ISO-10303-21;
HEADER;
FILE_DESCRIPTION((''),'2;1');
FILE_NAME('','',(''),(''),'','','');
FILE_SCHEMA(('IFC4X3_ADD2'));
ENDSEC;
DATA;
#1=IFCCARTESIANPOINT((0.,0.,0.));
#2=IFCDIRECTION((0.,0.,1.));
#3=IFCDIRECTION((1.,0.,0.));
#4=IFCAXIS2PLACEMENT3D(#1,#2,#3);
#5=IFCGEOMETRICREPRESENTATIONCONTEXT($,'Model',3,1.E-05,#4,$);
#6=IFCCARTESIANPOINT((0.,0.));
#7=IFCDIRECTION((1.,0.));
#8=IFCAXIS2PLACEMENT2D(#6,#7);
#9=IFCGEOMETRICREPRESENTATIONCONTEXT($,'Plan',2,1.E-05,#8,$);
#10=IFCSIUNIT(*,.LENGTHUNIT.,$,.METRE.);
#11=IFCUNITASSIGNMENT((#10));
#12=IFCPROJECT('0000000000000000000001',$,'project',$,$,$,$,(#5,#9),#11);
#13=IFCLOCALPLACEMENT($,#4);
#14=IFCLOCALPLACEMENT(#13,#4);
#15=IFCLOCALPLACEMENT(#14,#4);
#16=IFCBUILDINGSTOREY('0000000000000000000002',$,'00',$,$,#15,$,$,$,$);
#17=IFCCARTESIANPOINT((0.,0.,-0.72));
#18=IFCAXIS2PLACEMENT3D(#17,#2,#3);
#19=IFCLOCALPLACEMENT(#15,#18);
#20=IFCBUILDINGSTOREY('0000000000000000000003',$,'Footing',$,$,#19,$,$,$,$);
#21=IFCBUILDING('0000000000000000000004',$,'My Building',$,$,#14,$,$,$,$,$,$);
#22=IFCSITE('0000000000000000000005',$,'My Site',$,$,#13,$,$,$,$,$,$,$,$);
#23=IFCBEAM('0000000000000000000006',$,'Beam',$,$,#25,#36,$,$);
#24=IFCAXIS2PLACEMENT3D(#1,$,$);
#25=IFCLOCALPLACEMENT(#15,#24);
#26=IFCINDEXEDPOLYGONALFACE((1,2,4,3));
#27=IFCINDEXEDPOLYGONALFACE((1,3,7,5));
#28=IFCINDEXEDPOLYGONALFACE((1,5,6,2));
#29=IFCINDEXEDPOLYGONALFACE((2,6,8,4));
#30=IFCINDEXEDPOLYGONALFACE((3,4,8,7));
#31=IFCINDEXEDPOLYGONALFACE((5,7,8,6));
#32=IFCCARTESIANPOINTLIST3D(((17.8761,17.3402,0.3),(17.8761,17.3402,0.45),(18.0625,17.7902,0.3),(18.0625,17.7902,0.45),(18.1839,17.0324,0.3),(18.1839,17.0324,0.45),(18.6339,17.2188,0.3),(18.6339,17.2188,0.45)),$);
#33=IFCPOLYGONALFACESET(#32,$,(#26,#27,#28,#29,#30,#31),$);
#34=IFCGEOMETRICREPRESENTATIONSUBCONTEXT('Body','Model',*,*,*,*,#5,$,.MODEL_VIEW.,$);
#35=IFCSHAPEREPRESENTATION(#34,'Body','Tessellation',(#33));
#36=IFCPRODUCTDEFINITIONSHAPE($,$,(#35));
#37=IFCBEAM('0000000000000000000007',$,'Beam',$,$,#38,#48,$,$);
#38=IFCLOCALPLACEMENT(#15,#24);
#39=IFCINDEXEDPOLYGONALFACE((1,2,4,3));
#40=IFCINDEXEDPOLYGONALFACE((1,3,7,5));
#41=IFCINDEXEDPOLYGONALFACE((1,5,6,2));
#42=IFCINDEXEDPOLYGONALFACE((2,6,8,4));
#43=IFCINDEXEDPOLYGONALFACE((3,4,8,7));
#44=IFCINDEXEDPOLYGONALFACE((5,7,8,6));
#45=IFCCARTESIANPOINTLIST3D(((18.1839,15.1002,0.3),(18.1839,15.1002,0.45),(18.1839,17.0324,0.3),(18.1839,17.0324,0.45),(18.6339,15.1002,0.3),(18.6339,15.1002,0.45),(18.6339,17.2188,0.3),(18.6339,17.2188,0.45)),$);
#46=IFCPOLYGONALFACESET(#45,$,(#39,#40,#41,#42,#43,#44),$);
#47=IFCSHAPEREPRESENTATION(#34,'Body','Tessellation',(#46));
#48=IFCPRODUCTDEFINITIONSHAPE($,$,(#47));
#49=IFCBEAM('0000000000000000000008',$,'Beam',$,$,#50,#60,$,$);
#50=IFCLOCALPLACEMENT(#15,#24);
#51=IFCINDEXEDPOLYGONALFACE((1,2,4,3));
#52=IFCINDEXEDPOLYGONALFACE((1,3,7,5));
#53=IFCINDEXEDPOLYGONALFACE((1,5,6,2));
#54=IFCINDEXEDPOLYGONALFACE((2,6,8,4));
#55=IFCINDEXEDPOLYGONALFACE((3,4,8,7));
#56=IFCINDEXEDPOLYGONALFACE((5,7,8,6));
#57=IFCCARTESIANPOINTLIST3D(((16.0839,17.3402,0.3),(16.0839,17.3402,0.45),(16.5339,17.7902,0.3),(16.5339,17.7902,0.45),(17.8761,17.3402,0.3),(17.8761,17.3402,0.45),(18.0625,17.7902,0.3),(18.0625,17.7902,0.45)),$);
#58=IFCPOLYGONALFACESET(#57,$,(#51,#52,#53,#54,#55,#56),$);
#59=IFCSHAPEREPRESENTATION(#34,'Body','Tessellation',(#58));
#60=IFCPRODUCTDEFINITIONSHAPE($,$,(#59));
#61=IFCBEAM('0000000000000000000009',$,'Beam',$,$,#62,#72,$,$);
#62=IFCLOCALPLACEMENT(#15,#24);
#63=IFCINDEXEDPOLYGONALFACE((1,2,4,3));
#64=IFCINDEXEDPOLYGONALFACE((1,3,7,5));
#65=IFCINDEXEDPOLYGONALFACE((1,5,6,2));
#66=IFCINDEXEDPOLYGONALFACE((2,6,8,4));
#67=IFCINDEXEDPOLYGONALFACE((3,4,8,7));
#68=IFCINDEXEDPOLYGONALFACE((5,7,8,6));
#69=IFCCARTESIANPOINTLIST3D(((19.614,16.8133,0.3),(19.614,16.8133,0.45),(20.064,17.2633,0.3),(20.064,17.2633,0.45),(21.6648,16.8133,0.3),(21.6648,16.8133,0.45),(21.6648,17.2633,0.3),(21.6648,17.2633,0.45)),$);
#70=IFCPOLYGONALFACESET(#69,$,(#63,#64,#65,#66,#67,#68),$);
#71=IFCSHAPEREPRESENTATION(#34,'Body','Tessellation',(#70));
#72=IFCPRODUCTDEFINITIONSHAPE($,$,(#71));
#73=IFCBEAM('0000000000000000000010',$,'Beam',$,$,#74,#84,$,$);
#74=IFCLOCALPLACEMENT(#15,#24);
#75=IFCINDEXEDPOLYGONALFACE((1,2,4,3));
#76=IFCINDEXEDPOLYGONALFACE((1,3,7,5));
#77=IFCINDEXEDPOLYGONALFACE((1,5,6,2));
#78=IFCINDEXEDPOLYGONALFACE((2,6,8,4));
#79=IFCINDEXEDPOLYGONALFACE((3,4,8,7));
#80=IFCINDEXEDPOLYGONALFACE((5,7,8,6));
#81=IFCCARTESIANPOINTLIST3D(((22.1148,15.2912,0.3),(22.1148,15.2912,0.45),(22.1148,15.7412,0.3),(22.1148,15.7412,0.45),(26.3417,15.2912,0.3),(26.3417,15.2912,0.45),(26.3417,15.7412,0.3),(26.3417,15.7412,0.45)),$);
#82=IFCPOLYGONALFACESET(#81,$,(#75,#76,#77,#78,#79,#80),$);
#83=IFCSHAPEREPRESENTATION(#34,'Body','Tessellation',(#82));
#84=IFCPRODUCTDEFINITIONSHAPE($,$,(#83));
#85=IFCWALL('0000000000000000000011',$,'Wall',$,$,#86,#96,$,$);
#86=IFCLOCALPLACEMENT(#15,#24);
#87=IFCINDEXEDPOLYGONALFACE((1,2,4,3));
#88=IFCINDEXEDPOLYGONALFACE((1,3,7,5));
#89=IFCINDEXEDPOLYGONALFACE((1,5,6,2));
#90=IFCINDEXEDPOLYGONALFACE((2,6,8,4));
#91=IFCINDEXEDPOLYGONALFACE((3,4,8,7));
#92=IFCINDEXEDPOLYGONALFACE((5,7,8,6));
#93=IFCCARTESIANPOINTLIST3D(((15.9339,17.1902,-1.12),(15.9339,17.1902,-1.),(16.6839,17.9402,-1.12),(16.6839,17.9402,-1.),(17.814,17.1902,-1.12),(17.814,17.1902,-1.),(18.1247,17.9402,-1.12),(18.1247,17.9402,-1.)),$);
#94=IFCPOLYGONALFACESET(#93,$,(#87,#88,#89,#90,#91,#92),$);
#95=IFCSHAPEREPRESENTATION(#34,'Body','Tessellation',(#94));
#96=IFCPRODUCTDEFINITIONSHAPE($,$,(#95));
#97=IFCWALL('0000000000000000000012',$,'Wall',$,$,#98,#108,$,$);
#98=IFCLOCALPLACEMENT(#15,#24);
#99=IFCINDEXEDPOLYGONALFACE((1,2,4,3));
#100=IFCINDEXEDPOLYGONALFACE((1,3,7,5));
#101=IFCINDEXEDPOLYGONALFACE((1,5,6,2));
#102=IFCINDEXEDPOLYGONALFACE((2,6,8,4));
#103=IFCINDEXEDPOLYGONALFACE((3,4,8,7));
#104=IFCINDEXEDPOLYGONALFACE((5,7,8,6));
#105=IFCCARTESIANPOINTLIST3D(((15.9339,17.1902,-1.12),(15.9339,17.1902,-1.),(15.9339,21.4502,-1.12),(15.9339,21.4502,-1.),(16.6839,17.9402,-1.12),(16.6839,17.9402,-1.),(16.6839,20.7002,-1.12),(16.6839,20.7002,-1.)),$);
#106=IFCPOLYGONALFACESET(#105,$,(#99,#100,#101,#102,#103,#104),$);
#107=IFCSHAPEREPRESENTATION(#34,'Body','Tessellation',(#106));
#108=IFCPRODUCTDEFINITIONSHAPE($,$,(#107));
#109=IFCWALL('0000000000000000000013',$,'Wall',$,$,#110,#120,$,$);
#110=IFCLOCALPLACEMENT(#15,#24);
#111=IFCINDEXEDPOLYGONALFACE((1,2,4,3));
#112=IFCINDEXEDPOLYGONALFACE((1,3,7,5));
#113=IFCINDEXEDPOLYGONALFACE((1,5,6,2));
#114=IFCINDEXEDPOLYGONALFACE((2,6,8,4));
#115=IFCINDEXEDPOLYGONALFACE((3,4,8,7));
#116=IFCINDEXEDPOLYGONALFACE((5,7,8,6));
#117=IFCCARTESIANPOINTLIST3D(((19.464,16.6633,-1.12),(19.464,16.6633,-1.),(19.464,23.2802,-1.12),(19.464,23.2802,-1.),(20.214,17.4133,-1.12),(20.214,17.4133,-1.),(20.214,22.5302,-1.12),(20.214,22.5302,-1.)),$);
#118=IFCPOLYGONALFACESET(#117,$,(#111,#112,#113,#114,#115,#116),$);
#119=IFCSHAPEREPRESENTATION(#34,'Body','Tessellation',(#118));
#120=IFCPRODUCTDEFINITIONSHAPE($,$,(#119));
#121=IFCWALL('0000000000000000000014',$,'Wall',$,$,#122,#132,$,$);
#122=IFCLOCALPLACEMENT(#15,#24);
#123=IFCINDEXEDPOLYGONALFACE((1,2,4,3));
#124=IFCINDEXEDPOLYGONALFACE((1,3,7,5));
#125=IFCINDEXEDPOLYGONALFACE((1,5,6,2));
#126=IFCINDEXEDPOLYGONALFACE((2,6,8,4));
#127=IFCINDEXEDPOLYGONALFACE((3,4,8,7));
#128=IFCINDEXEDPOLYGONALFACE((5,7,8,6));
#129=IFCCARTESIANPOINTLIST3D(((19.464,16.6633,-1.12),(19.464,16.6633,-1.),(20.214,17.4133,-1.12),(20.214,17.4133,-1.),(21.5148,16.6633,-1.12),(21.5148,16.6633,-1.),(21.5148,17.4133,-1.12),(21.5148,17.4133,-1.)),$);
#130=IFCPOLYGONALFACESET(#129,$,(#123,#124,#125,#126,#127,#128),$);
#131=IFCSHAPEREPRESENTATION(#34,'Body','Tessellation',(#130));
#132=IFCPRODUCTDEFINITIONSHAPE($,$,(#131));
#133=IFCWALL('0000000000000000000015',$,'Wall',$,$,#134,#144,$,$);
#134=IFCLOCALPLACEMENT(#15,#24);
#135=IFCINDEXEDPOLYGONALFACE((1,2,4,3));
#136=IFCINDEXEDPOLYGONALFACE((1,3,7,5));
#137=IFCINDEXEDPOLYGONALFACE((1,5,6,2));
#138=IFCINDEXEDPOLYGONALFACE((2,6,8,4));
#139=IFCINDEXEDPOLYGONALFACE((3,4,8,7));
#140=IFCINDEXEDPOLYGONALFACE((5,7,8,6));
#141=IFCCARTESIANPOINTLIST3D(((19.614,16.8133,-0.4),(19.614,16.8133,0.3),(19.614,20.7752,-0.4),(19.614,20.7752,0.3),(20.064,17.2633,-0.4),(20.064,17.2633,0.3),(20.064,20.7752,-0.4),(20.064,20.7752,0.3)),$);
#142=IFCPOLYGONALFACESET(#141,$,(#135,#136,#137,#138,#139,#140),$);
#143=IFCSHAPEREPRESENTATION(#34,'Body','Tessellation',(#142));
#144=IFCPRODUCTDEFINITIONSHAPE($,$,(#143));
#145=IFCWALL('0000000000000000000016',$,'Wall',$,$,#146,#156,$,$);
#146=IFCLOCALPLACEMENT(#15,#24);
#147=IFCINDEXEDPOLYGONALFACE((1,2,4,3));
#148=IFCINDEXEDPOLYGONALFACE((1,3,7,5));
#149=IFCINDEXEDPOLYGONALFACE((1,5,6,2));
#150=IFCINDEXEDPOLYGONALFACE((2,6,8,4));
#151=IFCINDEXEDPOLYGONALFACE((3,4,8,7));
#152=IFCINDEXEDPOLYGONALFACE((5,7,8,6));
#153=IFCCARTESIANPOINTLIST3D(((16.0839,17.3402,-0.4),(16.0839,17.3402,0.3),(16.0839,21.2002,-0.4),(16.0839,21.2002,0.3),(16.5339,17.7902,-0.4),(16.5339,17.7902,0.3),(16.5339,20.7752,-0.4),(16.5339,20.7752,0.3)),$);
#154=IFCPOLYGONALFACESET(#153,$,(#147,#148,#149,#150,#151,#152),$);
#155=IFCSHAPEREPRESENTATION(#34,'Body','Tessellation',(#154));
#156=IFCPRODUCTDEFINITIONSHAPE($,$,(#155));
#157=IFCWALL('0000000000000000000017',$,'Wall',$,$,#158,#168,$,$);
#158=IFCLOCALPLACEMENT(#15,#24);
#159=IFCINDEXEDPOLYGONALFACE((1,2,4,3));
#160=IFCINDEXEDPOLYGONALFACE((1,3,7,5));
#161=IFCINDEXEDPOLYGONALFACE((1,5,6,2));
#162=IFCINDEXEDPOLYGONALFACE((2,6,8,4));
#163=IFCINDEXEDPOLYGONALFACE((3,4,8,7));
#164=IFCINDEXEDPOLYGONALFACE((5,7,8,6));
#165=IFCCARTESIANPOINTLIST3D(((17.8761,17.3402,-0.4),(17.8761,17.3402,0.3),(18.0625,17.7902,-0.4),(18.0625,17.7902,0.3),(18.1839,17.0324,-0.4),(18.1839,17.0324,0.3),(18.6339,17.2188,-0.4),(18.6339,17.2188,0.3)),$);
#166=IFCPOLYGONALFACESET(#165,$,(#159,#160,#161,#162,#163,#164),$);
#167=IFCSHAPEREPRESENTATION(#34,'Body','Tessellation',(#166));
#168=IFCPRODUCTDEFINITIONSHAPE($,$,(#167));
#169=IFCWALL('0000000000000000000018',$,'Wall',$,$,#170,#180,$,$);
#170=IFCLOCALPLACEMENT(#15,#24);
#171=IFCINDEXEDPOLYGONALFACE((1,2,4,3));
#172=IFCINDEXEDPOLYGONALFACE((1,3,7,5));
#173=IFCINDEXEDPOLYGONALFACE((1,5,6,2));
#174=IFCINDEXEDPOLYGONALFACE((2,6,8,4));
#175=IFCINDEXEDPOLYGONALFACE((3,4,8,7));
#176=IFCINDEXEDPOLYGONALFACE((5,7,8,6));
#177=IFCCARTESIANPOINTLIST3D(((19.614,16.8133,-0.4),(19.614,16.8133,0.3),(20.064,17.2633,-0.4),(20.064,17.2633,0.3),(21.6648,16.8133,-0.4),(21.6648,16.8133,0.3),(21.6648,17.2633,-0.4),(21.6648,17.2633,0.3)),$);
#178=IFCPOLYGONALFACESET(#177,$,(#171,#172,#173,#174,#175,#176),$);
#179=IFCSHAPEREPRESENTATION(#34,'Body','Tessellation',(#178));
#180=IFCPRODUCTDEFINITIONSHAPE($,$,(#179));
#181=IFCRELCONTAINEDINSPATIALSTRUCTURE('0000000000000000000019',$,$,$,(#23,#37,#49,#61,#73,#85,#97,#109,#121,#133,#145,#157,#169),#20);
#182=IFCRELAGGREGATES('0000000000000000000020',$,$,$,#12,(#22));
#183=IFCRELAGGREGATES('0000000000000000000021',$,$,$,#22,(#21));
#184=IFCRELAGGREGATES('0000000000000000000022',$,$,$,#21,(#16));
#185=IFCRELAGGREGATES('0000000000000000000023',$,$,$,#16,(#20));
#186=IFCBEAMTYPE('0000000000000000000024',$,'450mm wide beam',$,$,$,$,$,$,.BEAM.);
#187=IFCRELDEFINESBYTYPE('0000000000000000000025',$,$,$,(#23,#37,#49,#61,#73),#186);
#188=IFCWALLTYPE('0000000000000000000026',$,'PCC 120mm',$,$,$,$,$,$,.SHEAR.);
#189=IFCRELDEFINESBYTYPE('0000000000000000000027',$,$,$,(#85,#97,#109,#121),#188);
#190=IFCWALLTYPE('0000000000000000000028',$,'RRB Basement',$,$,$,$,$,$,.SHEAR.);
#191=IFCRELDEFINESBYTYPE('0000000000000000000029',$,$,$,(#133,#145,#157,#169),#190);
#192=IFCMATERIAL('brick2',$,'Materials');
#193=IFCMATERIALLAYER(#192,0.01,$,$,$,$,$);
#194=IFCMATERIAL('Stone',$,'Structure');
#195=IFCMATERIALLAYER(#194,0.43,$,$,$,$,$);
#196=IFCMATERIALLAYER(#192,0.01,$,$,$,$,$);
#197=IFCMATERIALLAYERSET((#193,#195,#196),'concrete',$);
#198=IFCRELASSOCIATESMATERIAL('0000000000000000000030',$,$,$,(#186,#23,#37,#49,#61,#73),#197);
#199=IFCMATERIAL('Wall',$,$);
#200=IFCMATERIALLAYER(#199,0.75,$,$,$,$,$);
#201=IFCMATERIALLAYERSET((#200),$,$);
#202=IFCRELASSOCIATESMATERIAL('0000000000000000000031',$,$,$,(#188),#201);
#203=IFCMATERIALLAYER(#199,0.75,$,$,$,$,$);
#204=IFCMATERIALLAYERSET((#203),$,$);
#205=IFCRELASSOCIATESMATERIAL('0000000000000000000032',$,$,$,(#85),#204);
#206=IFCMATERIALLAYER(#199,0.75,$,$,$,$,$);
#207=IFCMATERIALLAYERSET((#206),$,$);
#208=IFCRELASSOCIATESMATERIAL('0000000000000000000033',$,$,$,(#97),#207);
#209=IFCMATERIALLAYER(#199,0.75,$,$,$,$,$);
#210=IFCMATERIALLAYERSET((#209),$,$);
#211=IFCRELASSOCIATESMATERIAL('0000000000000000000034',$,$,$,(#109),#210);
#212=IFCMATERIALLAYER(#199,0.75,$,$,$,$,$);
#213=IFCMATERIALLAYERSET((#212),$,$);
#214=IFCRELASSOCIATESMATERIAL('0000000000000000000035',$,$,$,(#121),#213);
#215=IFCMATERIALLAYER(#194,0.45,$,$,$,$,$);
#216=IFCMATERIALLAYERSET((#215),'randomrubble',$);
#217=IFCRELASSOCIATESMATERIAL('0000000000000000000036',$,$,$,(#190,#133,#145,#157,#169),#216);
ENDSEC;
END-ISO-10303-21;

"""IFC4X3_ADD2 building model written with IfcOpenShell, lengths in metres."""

from ifc_helpers import new_model, si_unit, frame, origin_with_axes, origin_2d_with_axis, place, context, subcontext, project, spatial, line, indexed_curve, outline, extrude, material, layer, layer_set, layer_usage, type_object, element, save


model = new_model("IFC4X3_ADD2")

# Units and contexts
model_context = context("Model", 3, precision=1e-05, world=origin_with_axes())
plan_context = context("Plan", 2, precision=1e-05, world=origin_2d_with_axis())
body_context = subcontext(model_context, "Body", "Model", "MODEL_VIEW")
ifc_project = project(units=[si_unit("LENGTHUNIT", "METRE")], contexts=[model_context, plan_context])

# Site, building, storeys
site_placement = place(None, origin_with_axes())
site = spatial("IfcSite", under=ifc_project, at=site_placement, Name="My Site")
building_placement = place(site_placement, origin_with_axes())
building = spatial("IfcBuilding", under=site, at=building_placement, Name="My Building")
storey_1_placement = place(building_placement, origin_with_axes())
storey_1 = spatial("IfcBuildingStorey", under=building, at=storey_1_placement, Name="00")
storey_2_placement = place(storey_1_placement, frame((0.0, 0.0, -0.72), z_axis=(0.0, 0.0, 1.0), x_axis=(1.0, 0.0, 0.0)))
storey_2 = spatial("IfcBuildingStorey", under=storey_1, at=storey_2_placement, Name="Footing")

# Beams
ifc_material_1 = material(Name="brick2", Category="Materials")
ifc_layer_1 = layer(ifc_material_1, 0.01)
ifc_material_2 = material(Name="Stone", Category="Structure")
ifc_layer_2 = layer(ifc_material_2, 0.43)
ifc_layer_3 = layer(ifc_material_1, 0.01)
ifc_layer_set_1 = layer_set([ifc_layer_1, ifc_layer_2, ifc_layer_3], Name="concrete")
ifc_layer_usage_1 = layer_usage(ifc_layer_set_1, "AXIS2", "NEGATIVE", 0.0)
beam_type = type_object("IfcBeamType", Name="450mm wide beam", PredefinedType="BEAM", material=ifc_layer_set_1)
beam_1_placement = place(storey_2_placement, frame((18.1839, 17.0324, 1.02), z_axis=(0.0, 0.0, 1.0), x_axis=(-0.707107, 0.707107, 0.0)))
element("IfcBeam", 1, at=beam_1_placement, inside=storey_2, type_object=beam_type, material=ifc_layer_usage_1, Name="Beam", context=body_context, shape_type="SweptSolid", body=[
    extrude(outline(indexed_curve([(-0.1864, -0.45), (0.0, 0.0), (0.4353, 0.0), (0.6217, -0.45)], segments=[line(1, 2, 3, 4, 1)])), origin_with_axes(), (0.0, 0.0, 1.0), 0.15),
])
ifc_layer_usage_2 = layer_usage(ifc_layer_set_1, "AXIS2", "POSITIVE", 0.0)
beam_2_placement = place(storey_2_placement, frame((18.1839, 17.0324, 1.02), z_axis=(0.0, 0.0, 1.0), x_axis=(0.0, -1.0, 0.0)))
element("IfcBeam", 2, at=beam_2_placement, inside=storey_2, type_object=beam_type, material=ifc_layer_usage_2, Name="Beam", context=body_context, shape_type="SweptSolid", body=[
    extrude(outline(indexed_curve([(0.0, 0.0), (-0.1864, 0.45), (1.9322, 0.45), (1.9322, 0.0)], segments=[line(1, 2, 3, 4, 1)])), origin_with_axes(), (0.0, 0.0, 1.0), 0.15),
])
ifc_layer_usage_3 = layer_usage(ifc_layer_set_1, "AXIS2", "POSITIVE", 0.0)
beam_3_placement = place(storey_2_placement, frame((16.0839, 17.3402, 1.02), z_axis=(0.0, 0.0, 1.0), x_axis=(1.0, 0.0, 0.0)))
element("IfcBeam", 3, at=beam_3_placement, inside=storey_2, type_object=beam_type, material=ifc_layer_usage_3, Name="Beam", context=body_context, shape_type="SweptSolid", body=[
    extrude(outline(indexed_curve([(0.0, 0.0), (0.45, 0.45), (1.9786, 0.45), (1.7922, 0.0)], segments=[line(1, 2, 3, 4, 1)])), origin_with_axes(), (0.0, 0.0, 1.0), 0.15),
])
ifc_layer_usage_4 = layer_usage(ifc_layer_set_1, "AXIS2", "NEGATIVE", 0.0)
beam_4_placement = place(storey_2_placement, frame((20.064, 17.2633, 1.02), z_axis=(0.0, 0.0, 1.0), x_axis=(1.0, 0.0, 0.0)))
element("IfcBeam", 4, at=beam_4_placement, inside=storey_2, type_object=beam_type, material=ifc_layer_usage_4, Name="Beam", context=body_context, shape_type="SweptSolid", body=[
    extrude(outline(indexed_curve([(-0.45, -0.45), (0.0, 0.0), (1.6008, 0.0), (1.6008, -0.45)], segments=[line(1, 2, 3, 4, 1)])), origin_with_axes(), (0.0, 0.0, 1.0), 0.15),
])
ifc_layer_usage_5 = layer_usage(ifc_layer_set_1, "AXIS2", "NEGATIVE", 0.0)
beam_5_placement = place(storey_2_placement, frame((22.1148, 15.7412, 1.02), z_axis=(0.0, 0.0, 1.0), x_axis=(1.0, 0.0, 0.0)))
element("IfcBeam", 5, at=beam_5_placement, inside=storey_2, type_object=beam_type, material=ifc_layer_usage_5, Name="Beam", context=body_context, shape_type="SweptSolid", body=[
    extrude(outline(indexed_curve([(0.0, -0.45), (0.0, 0.0), (4.2269, 0.0), (4.2269, -0.45)], segments=[line(1, 2, 3, 4, 1)])), origin_with_axes(), (0.0, 0.0, 1.0), 0.15),
])

# Walls
ifc_material_3 = material(Name="Wall")
ifc_layer_4 = layer(ifc_material_3, 0.75)
ifc_layer_set_2 = layer_set([ifc_layer_4])
ifc_layer_usage_6 = layer_usage(ifc_layer_set_2, "AXIS2", "POSITIVE", 0.0)
ifc_layer_5 = layer(ifc_material_3, 0.75)
ifc_layer_set_3 = layer_set([ifc_layer_5])
wall_type_1 = type_object("IfcWallType", Name="PCC 120mm", PredefinedType="SHEAR", material=ifc_layer_set_3)
wall_1_placement = place(storey_2_placement, frame((16.6839, 17.1902, -0.4), z_axis=(0.0, 0.0, 1.0), x_axis=(1.0, 0.0, 0.0)))
element("IfcWall", 6, at=wall_1_placement, inside=storey_2, type_object=wall_type_1, material=ifc_layer_usage_6, Name="Wall", context=body_context, shape_type="SweptSolid", body=[
    extrude(outline(indexed_curve([(-0.75, 0.0), (0.0, 0.75), (1.4407, 0.75), (1.1301, 0.0)], segments=[line(1, 2, 3, 4, 1)])), origin_with_axes(), (0.0, 0.0, 1.0), 0.12),
])
ifc_layer_6 = layer(ifc_material_3, 0.75)
ifc_layer_set_4 = layer_set([ifc_layer_6])
ifc_layer_usage_7 = layer_usage(ifc_layer_set_4, "AXIS2", "POSITIVE", 0.0)
wall_2_placement = place(storey_2_placement, frame((16.6839, 17.1902, -0.4), z_axis=(0.0, 0.0, 1.0), x_axis=(0.0, 1.0, 0.0)))
element("IfcWall", 7, at=wall_2_placement, inside=storey_2, type_object=wall_type_1, material=ifc_layer_usage_7, Name="Wall", context=body_context, shape_type="SweptSolid", body=[
    extrude(outline(indexed_curve([(0.75, 0.0), (0.0, 0.75), (4.26, 0.75), (3.51, 0.0)], segments=[line(1, 2, 3, 4, 1)])), origin_with_axes(), (0.0, 0.0, 1.0), 0.12),
])
ifc_layer_7 = layer(ifc_material_3, 0.75)
ifc_layer_set_5 = layer_set([ifc_layer_7])
ifc_layer_usage_8 = layer_usage(ifc_layer_set_5, "AXIS2", "POSITIVE", 0.0)
wall_3_placement = place(storey_2_placement, frame((20.214, 16.6633, -0.4), z_axis=(0.0, 0.0, 1.0), x_axis=(0.0, 1.0, 0.0)))
element("IfcWall", 8, at=wall_3_placement, inside=storey_2, type_object=wall_type_1, material=ifc_layer_usage_8, Name="Wall", context=body_context, shape_type="SweptSolid", body=[
    extrude(outline(indexed_curve([(0.75, 0.0), (0.0, 0.75), (6.6169, 0.75), (5.8669, 0.0)], segments=[line(1, 2, 3, 4, 1)])), origin_with_axes(), (0.0, 0.0, 1.0), 0.12),
])
ifc_layer_8 = layer(ifc_material_3, 0.75)
ifc_layer_set_6 = layer_set([ifc_layer_8])
ifc_layer_usage_9 = layer_usage(ifc_layer_set_6, "AXIS2", "POSITIVE", 0.0)
wall_4_placement = place(storey_2_placement, frame((20.214, 16.6633, -0.4), z_axis=(0.0, 0.0, 1.0), x_axis=(1.0, 0.0, 0.0)))
element("IfcWall", 9, at=wall_4_placement, inside=storey_2, type_object=wall_type_1, material=ifc_layer_usage_9, Name="Wall", context=body_context, shape_type="SweptSolid", body=[
    extrude(outline(indexed_curve([(-0.75, 0.0), (0.0, 0.75), (1.3008, 0.75), (1.3008, 0.0)], segments=[line(1, 2, 3, 4, 1)])), origin_with_axes(), (0.0, 0.0, 1.0), 0.12),
])
ifc_layer_9 = layer(ifc_material_2, 0.45)
ifc_layer_set_7 = layer_set([ifc_layer_9], Name="randomrubble")
ifc_layer_usage_10 = layer_usage(ifc_layer_set_7, "AXIS2", "NEGATIVE", 0.0)
wall_type_2 = type_object("IfcWallType", Name="RRB Basement", PredefinedType="SHEAR", material=ifc_layer_set_7)
wall_5_placement = place(storey_2_placement, frame((19.614, 16.8133, 0.32), z_axis=(0.0, 0.0, 1.0), x_axis=(0.0, 1.0, 0.0)))
element("IfcWall", 10, at=wall_5_placement, inside=storey_2, type_object=wall_type_2, material=ifc_layer_usage_10, Name="Wall", context=body_context, shape_type="SweptSolid", body=[
    extrude(outline(indexed_curve([(0.45, -0.45), (0.0, 0.0), (3.9619, 0.0), (3.9619, -0.45)], segments=[line(1, 2, 3, 4, 1)])), origin_with_axes(), (0.0, 0.0, 1.0), 0.7),
])
ifc_layer_usage_11 = layer_usage(ifc_layer_set_7, "AXIS2", "POSITIVE", 0.0)
wall_6_placement = place(storey_2_placement, frame((16.5339, 17.3402, 0.32), z_axis=(0.0, 0.0, 1.0), x_axis=(0.000001, 1.0, 0.0)))
element("IfcWall", 11, at=wall_6_placement, inside=storey_2, type_object=wall_type_2, material=ifc_layer_usage_11, Name="Wall", context=body_context, shape_type="SweptSolid", body=[
    extrude(outline(indexed_curve([(0.45, 0.0), (0.0, 0.45), (3.86, 0.45), (3.435, 0.0)], segments=[line(1, 2, 3, 4, 1)])), origin_with_axes(), (0.0, 0.0, 1.0), 0.7),
])
ifc_layer_usage_12 = layer_usage(ifc_layer_set_7, "AXIS2", "POSITIVE", 0.0)
wall_7_placement = place(storey_2_placement, frame((18.6339, 17.2188, 0.32), z_axis=(0.0, 0.0, 1.0), x_axis=(-0.707107, 0.707107, 0.0)))
element("IfcWall", 12, at=wall_7_placement, inside=storey_2, type_object=wall_type_2, material=ifc_layer_usage_12, Name="Wall", context=body_context, shape_type="SweptSolid", body=[
    extrude(outline(indexed_curve([(0.0, 0.0), (0.1864, 0.45), (0.6217, 0.45), (0.8081, 0.0)], segments=[line(1, 2, 3, 4, 1)])), origin_with_axes(), (0.0, 0.0, 1.0), 0.7),
])
ifc_layer_usage_13 = layer_usage(ifc_layer_set_7, "AXIS2", "POSITIVE", 0.0)
wall_8_placement = place(storey_2_placement, frame((19.614, 16.8133, 0.32), z_axis=(0.0, 0.0, 1.0), x_axis=(1.0, 0.0, 0.0)))
element("IfcWall", 13, at=wall_8_placement, inside=storey_2, type_object=wall_type_2, material=ifc_layer_usage_13, Name="Wall", context=body_context, shape_type="SweptSolid", body=[
    extrude(outline(indexed_curve([(0.0, 0.0), (0.45, 0.45), (2.0508, 0.45), (2.0508, 0.0)], segments=[line(1, 2, 3, 4, 1)])), origin_with_axes(), (0.0, 0.0, 1.0), 0.7),
])

save(model, "model.ifc")
